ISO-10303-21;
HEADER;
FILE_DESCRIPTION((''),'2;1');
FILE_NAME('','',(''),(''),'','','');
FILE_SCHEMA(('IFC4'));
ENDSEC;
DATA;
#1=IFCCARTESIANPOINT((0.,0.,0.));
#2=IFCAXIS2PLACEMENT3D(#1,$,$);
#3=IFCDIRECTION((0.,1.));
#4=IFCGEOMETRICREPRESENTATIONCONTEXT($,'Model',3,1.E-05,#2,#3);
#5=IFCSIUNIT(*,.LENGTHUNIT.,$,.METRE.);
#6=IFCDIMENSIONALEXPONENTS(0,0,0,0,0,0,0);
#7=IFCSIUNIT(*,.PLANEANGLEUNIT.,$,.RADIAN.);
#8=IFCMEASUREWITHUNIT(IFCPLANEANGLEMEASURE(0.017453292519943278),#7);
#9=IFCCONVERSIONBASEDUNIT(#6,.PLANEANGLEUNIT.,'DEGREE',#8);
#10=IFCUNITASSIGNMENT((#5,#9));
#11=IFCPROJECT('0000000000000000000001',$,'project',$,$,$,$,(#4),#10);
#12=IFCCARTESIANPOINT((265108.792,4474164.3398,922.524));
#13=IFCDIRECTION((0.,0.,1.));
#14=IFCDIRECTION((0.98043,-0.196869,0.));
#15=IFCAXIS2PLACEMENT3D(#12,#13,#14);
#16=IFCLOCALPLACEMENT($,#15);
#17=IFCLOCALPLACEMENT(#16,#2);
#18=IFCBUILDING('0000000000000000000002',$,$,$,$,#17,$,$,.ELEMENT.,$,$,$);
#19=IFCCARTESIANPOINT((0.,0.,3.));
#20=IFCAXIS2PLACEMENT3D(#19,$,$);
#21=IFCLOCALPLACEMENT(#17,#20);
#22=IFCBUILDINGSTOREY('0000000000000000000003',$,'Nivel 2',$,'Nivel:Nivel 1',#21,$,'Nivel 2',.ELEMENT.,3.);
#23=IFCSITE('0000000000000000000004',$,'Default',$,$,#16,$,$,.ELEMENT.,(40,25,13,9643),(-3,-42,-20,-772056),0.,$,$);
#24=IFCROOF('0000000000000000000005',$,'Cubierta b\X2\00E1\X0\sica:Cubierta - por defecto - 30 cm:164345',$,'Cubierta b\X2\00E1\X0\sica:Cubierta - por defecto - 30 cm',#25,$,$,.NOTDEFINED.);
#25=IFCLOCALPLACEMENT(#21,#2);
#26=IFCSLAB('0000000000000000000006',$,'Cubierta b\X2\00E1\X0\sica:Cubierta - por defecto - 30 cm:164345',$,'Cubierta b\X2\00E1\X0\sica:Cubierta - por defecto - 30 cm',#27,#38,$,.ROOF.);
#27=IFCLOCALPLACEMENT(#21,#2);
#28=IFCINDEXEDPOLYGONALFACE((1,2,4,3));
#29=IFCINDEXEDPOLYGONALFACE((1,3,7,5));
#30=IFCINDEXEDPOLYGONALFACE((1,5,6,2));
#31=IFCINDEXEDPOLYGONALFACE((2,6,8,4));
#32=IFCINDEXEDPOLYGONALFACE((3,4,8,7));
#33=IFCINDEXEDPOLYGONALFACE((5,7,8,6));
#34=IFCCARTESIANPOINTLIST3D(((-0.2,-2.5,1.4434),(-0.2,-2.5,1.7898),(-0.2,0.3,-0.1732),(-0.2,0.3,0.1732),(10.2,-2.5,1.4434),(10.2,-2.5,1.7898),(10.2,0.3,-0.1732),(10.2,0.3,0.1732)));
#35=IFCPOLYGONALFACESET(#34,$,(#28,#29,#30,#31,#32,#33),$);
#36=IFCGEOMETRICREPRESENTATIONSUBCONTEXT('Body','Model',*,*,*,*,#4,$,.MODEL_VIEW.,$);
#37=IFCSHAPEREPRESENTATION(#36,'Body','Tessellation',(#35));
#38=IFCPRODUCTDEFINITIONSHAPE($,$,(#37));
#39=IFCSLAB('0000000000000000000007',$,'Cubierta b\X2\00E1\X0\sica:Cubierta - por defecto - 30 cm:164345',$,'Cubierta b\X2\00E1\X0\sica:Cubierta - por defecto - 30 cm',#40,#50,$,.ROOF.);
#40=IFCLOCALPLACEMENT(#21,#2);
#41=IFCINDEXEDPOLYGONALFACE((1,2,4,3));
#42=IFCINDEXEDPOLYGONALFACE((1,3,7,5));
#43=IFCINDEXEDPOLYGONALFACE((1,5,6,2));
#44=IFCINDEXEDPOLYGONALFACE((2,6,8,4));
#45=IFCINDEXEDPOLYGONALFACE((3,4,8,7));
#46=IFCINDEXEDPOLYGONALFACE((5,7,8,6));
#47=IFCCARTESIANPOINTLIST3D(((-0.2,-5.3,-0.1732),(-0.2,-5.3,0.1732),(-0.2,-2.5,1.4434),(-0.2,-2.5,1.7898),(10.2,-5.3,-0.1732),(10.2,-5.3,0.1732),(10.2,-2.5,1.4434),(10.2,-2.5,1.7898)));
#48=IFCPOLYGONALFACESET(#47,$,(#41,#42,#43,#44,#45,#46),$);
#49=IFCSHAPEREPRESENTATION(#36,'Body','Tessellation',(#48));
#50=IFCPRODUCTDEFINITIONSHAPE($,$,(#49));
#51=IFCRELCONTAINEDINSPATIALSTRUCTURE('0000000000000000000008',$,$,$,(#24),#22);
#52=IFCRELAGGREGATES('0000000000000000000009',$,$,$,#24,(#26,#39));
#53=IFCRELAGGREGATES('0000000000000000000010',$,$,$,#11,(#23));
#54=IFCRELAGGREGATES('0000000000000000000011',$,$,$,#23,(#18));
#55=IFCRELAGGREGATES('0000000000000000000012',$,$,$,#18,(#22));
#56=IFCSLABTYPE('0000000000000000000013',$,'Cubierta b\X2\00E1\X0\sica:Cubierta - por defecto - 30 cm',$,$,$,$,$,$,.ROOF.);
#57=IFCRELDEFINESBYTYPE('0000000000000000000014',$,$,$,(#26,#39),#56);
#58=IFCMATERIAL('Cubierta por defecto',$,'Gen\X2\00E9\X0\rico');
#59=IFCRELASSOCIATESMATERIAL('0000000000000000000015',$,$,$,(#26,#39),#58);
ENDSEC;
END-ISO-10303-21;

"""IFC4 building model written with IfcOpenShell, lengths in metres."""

from ifc_helpers import new_model, entity, si_unit, converted_unit, direction, frame, origin, place, context, subcontext, project, spatial, indexed_curve, outline, extrude, material, type_object, element, aggregate, save


model = new_model("IFC4")

# Units and contexts
model_context = context("Model", 3, precision=1e-05, world=origin(), true_north=direction((0.0, 1.0)))
body_context = subcontext(model_context, "Body", "Model", "MODEL_VIEW")
ifc_project = project(units=[si_unit("LENGTHUNIT", "METRE"), converted_unit("PLANEANGLEUNIT", "DEGREE", entity("IfcPlaneAngleMeasure", 0.017453292519943278), si_unit("PLANEANGLEUNIT", "RADIAN"), dimensions=[0, 0, 0, 0, 0, 0, 0])], contexts=[model_context])

# Site, building, storey
site_placement = place(None, frame((265108.792, 4474164.3398, 922.524), z_axis=(0.0, 0.0, 1.0), x_axis=(0.98043, -0.196869, 0.0)))
site = spatial("IfcSite", under=ifc_project, at=site_placement, Name="Default", CompositionType="ELEMENT", RefLatitude=(40, 25, 13, 9643), RefLongitude=(-3, -42, -20, -772056), RefElevation=0.0)
building_placement = place(site_placement, origin())
building = spatial("IfcBuilding", under=site, at=building_placement, CompositionType="ELEMENT")
storey_placement = place(building_placement, frame((0.0, 0.0, 3.0)))
storey = spatial("IfcBuildingStorey", under=building, at=storey_placement, Name="Nivel 2", ObjectType="Nivel:Nivel 1", LongName="Nivel 2", CompositionType="ELEMENT", Elevation=3.0)

# Roof, slabs
roof_placement = place(storey_placement, frame((-0.2, -5.3, -0.1732)))
roof = element("IfcRoof", 1, at=roof_placement, inside=storey, Name="Cubierta básica:Cubierta - por defecto - 30 cm:164345", ObjectType="Cubierta básica:Cubierta - por defecto - 30 cm", PredefinedType="NOTDEFINED")
ifc_material = material(Name="Cubierta por defecto", Category="Genérico")
slab_type = type_object("IfcSlabType", Name="Cubierta básica:Cubierta - por defecto - 30 cm", PredefinedType="ROOF")
slab_1_placement = place(roof_placement, origin())
slab_1 = element("IfcSlab", 2, at=slab_1_placement, type_object=slab_type, material=ifc_material, Name="Cubierta básica:Cubierta - por defecto - 30 cm:164345", ObjectType="Cubierta básica:Cubierta - por defecto - 30 cm", PredefinedType="ROOF", context=body_context, shape_type="SweptSolid", body=[
    extrude(outline(indexed_curve([(-5.2, 1.6166), (-5.2, -1.6166), (5.2, -1.6166), (5.2, 1.6166), (-5.2, 1.6166)], self_intersect=False)), frame((5.2, 4.2, 0.8083), z_axis=(0.0, 0.5, 0.866025), x_axis=(1.0, 0.0, 0.0)), (0.0, -0.5, 0.866025), 0.3464),
])
slab_2_placement = place(roof_placement, origin())
slab_2 = element("IfcSlab", 3, at=slab_2_placement, type_object=slab_type, material=ifc_material, Name="Cubierta básica:Cubierta - por defecto - 30 cm:164345", ObjectType="Cubierta básica:Cubierta - por defecto - 30 cm", PredefinedType="ROOF", context=body_context, shape_type="SweptSolid", body=[
    extrude(outline(indexed_curve([(5.2, 1.6166), (-5.2, 1.6166), (-5.2, -1.6166), (5.2, -1.6166), (5.2, 1.6166)], self_intersect=False)), frame((5.2, 1.4, 0.8083), z_axis=(0.0, -0.5, 0.866025), x_axis=(1.0, 0.0, 0.0)), (0.0, 0.5, 0.866025), 0.3464),
])
aggregate(roof, [slab_1, slab_2])

save(model, "model.ifc")
